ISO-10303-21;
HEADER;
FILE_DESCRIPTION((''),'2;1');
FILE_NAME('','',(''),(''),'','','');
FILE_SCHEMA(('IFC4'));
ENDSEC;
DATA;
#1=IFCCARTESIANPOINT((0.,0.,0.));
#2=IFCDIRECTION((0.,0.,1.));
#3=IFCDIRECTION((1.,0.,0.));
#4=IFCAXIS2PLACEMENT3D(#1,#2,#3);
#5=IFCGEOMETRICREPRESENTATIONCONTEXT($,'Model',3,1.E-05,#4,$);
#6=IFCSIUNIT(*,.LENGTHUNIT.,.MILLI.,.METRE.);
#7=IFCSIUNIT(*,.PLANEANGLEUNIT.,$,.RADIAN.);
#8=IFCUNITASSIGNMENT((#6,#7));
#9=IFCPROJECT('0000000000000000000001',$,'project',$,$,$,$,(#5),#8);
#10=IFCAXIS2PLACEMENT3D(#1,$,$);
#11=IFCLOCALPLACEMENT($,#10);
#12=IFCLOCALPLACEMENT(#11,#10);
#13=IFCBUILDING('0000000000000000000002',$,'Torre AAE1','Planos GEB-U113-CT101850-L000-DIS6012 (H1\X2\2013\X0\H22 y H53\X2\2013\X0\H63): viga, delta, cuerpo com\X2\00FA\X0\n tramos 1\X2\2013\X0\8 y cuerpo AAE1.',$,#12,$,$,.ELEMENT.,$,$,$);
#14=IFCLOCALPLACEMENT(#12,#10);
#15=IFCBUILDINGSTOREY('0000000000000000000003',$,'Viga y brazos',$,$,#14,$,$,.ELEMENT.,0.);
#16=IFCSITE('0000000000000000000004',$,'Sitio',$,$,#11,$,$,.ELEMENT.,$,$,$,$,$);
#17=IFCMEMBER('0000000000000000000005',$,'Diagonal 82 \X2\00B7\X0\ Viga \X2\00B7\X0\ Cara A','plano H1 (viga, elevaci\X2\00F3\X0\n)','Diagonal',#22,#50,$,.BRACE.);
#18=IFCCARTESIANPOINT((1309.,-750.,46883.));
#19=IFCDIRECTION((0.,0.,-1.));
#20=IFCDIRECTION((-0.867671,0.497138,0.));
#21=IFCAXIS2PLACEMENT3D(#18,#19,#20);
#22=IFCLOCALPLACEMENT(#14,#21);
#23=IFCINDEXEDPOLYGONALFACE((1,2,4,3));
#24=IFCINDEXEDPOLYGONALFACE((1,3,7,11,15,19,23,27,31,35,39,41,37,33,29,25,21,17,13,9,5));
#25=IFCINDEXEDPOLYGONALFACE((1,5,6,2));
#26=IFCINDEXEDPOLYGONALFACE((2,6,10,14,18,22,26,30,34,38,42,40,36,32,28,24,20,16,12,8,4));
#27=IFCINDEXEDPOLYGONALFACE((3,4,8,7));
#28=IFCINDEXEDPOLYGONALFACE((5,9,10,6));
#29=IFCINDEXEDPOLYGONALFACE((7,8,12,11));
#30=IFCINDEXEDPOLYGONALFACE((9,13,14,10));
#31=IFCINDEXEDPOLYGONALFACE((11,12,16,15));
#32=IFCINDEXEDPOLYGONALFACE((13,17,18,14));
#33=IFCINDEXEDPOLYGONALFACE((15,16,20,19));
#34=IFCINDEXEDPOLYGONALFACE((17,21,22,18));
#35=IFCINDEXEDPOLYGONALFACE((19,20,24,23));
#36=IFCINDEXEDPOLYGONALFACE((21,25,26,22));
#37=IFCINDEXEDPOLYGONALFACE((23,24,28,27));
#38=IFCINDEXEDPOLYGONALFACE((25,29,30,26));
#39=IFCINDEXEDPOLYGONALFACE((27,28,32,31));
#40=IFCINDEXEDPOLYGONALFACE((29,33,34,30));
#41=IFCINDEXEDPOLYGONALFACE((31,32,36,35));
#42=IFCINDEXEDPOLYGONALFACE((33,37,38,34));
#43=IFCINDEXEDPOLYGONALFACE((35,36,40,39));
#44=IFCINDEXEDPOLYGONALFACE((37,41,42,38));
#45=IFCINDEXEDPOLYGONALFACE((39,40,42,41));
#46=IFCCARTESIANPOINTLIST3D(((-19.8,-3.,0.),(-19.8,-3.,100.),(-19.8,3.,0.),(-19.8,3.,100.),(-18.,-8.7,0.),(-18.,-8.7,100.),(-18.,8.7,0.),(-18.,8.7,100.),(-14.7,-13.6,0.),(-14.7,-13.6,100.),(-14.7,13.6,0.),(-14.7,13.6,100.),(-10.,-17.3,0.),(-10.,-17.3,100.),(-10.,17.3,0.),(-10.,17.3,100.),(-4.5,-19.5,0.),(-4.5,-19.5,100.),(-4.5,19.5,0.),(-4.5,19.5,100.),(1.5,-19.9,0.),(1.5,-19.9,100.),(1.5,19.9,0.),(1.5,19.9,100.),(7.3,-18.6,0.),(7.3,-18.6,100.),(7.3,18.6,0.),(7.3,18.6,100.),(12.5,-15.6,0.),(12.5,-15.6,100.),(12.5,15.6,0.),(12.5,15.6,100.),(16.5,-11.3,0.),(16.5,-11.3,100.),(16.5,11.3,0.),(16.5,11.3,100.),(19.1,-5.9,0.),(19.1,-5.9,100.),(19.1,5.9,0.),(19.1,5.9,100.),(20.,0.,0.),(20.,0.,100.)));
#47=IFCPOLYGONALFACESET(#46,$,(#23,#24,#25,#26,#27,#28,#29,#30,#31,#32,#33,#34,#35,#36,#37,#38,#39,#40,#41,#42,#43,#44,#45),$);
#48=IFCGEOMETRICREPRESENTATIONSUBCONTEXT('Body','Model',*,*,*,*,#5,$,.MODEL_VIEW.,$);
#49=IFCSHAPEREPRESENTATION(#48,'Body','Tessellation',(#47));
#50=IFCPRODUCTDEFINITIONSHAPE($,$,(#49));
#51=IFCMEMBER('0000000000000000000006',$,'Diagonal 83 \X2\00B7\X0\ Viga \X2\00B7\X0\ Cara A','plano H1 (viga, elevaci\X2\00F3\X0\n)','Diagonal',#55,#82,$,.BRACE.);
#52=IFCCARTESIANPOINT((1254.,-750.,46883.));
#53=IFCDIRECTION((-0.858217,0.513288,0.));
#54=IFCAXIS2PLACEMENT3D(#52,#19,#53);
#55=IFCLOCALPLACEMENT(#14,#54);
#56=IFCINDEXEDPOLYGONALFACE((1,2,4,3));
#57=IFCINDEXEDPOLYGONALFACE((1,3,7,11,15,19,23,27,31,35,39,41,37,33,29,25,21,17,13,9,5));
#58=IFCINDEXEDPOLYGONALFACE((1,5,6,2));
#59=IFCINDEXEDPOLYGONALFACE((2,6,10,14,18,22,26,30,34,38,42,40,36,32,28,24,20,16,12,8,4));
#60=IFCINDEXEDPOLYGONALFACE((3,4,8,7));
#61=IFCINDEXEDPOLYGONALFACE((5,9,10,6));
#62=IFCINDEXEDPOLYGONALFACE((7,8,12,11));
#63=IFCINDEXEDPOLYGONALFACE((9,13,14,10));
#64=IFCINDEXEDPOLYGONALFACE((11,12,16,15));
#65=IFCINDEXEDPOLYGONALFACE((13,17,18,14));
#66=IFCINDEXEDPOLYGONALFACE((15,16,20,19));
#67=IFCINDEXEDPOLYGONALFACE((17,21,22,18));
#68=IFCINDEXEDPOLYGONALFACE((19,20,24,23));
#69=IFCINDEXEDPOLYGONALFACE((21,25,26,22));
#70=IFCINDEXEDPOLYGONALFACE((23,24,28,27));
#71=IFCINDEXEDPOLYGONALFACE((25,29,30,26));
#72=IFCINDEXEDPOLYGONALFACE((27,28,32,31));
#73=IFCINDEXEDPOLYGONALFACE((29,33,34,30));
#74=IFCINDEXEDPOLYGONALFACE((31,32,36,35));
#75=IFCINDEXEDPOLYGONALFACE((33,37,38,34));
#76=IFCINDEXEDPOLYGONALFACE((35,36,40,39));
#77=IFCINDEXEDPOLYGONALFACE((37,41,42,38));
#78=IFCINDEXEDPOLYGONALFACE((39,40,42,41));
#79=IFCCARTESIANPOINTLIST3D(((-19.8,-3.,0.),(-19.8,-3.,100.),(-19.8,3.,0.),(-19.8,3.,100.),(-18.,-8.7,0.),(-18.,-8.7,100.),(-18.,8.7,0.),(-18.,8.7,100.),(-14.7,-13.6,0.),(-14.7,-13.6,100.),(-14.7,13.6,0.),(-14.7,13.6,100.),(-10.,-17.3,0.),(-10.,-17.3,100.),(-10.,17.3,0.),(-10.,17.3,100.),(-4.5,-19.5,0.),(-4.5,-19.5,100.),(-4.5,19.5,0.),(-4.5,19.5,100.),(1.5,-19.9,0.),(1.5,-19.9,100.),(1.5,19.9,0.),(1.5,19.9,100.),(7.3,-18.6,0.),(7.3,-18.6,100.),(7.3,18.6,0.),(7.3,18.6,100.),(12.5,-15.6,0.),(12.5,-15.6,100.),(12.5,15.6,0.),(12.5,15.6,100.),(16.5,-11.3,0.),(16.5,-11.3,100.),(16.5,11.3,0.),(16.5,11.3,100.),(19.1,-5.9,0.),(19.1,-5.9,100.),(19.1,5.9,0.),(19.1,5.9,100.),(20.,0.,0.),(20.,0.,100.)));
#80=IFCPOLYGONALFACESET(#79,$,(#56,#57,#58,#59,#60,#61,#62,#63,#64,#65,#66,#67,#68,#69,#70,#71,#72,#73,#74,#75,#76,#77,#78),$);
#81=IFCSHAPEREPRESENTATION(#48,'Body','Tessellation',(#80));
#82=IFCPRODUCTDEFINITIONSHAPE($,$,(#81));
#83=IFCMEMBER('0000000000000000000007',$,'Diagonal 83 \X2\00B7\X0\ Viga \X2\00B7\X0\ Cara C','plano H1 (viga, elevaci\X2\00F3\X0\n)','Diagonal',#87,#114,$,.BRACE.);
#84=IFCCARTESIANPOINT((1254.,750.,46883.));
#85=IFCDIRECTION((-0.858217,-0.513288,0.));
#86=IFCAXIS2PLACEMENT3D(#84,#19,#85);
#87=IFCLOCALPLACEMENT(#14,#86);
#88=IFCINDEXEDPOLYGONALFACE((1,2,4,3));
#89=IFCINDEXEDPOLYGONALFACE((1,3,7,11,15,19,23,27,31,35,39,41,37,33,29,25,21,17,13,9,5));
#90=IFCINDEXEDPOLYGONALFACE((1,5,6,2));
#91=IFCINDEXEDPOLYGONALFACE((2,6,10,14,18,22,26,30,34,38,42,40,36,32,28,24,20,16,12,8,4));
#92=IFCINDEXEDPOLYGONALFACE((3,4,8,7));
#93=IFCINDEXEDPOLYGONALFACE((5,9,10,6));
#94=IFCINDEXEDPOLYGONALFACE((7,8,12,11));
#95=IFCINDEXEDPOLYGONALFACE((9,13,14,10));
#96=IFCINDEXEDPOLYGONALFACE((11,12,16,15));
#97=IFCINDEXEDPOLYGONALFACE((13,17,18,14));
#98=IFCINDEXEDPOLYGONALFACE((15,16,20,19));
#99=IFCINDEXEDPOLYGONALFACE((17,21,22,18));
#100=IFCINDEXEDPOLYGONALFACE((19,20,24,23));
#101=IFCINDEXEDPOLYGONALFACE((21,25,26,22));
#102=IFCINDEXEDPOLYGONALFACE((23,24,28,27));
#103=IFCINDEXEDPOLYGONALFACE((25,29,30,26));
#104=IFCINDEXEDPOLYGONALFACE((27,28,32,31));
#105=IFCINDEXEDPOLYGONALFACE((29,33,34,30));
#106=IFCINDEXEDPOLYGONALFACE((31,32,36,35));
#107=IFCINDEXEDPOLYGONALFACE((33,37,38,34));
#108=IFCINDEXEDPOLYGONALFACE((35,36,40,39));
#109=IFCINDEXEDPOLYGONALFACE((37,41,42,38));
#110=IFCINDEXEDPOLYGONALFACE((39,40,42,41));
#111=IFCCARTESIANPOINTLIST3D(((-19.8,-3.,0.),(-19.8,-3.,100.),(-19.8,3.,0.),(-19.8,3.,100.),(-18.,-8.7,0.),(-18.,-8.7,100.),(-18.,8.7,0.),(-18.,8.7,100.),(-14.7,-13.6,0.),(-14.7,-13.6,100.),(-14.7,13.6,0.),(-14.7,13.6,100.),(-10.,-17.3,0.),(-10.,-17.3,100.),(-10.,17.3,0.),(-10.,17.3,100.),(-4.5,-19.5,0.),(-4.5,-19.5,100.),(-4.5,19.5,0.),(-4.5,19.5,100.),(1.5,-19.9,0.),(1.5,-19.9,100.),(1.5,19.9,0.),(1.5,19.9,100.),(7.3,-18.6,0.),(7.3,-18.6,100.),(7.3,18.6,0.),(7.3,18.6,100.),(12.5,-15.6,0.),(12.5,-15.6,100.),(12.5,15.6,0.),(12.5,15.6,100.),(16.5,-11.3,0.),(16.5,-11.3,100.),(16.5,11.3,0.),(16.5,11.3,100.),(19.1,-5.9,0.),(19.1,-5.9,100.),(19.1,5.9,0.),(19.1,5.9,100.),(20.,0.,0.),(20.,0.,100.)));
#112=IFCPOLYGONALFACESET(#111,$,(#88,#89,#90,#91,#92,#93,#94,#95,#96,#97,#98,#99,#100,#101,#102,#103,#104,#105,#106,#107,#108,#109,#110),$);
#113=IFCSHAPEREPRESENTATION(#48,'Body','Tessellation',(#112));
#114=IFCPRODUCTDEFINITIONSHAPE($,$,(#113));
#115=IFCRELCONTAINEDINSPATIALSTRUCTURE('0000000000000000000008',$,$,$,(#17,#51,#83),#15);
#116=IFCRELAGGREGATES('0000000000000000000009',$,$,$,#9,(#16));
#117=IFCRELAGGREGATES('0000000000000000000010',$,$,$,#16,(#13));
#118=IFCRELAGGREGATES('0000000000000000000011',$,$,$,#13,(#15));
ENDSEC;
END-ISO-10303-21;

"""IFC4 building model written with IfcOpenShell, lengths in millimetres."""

from ifc_helpers import new_model, si_unit, frame, origin, origin_with_axes, place, context, subcontext, project, spatial, circle, extrude, element, save


model = new_model("IFC4")

# Units and contexts
model_context = context("Model", 3, precision=1e-05, world=origin_with_axes())
body_context = subcontext(model_context, "Body", "Model", "MODEL_VIEW")
ifc_project = project(units=[si_unit("LENGTHUNIT", "METRE", prefix="MILLI"), si_unit("PLANEANGLEUNIT", "RADIAN")], contexts=[model_context])

# Site, building, storey
site_placement = place(None, origin())
site = spatial("IfcSite", under=ifc_project, at=site_placement, Name="Sitio", CompositionType="ELEMENT")
building_placement = place(site_placement, origin())
building = spatial("IfcBuilding", under=site, at=building_placement, Name="Torre AAE1", Description="Planos GEB-U113-CT101850-L000-DIS6012 (H1–H22 y H53–H63): viga, delta, cuerpo común tramos 1–8 y cuerpo AAE1.", CompositionType="ELEMENT")
storey_placement = place(building_placement, origin())
storey = spatial("IfcBuildingStorey", under=building, at=storey_placement, Name="Viga y brazos", CompositionType="ELEMENT", Elevation=0.0)

# Members
for number, where, z_axis, x_axis, name in (
    (1, (1309.0, -750.0, 46883.0), (0.0, 0.0, -1.0), (-0.867671, 0.497138, 0.0), "Diagonal 82 · Viga · Cara A"),
    (2, (1254.0, -750.0, 46883.0), (0.0, 0.0, -1.0), (-0.858217, 0.513288, 0.0), "Diagonal 83 · Viga · Cara A"),
    (3, (1254.0, 750.0, 46883.0), (0.0, 0.0, -1.0), (-0.858217, -0.513288, 0.0), "Diagonal 83 · Viga · Cara C"),
):
    element("IfcMember", number, at=place(storey_placement, frame(where, z_axis=z_axis, x_axis=x_axis)), inside=storey, Name=name, Description="plano H1 (viga, elevación)", ObjectType="Diagonal", PredefinedType="BRACE", context=body_context, shape_type="SweptSolid", body=[
        extrude(circle(Radius=20.0), None, (0.0, 0.0, 1.0), 100.0),
    ])

save(model, "model.ifc")
